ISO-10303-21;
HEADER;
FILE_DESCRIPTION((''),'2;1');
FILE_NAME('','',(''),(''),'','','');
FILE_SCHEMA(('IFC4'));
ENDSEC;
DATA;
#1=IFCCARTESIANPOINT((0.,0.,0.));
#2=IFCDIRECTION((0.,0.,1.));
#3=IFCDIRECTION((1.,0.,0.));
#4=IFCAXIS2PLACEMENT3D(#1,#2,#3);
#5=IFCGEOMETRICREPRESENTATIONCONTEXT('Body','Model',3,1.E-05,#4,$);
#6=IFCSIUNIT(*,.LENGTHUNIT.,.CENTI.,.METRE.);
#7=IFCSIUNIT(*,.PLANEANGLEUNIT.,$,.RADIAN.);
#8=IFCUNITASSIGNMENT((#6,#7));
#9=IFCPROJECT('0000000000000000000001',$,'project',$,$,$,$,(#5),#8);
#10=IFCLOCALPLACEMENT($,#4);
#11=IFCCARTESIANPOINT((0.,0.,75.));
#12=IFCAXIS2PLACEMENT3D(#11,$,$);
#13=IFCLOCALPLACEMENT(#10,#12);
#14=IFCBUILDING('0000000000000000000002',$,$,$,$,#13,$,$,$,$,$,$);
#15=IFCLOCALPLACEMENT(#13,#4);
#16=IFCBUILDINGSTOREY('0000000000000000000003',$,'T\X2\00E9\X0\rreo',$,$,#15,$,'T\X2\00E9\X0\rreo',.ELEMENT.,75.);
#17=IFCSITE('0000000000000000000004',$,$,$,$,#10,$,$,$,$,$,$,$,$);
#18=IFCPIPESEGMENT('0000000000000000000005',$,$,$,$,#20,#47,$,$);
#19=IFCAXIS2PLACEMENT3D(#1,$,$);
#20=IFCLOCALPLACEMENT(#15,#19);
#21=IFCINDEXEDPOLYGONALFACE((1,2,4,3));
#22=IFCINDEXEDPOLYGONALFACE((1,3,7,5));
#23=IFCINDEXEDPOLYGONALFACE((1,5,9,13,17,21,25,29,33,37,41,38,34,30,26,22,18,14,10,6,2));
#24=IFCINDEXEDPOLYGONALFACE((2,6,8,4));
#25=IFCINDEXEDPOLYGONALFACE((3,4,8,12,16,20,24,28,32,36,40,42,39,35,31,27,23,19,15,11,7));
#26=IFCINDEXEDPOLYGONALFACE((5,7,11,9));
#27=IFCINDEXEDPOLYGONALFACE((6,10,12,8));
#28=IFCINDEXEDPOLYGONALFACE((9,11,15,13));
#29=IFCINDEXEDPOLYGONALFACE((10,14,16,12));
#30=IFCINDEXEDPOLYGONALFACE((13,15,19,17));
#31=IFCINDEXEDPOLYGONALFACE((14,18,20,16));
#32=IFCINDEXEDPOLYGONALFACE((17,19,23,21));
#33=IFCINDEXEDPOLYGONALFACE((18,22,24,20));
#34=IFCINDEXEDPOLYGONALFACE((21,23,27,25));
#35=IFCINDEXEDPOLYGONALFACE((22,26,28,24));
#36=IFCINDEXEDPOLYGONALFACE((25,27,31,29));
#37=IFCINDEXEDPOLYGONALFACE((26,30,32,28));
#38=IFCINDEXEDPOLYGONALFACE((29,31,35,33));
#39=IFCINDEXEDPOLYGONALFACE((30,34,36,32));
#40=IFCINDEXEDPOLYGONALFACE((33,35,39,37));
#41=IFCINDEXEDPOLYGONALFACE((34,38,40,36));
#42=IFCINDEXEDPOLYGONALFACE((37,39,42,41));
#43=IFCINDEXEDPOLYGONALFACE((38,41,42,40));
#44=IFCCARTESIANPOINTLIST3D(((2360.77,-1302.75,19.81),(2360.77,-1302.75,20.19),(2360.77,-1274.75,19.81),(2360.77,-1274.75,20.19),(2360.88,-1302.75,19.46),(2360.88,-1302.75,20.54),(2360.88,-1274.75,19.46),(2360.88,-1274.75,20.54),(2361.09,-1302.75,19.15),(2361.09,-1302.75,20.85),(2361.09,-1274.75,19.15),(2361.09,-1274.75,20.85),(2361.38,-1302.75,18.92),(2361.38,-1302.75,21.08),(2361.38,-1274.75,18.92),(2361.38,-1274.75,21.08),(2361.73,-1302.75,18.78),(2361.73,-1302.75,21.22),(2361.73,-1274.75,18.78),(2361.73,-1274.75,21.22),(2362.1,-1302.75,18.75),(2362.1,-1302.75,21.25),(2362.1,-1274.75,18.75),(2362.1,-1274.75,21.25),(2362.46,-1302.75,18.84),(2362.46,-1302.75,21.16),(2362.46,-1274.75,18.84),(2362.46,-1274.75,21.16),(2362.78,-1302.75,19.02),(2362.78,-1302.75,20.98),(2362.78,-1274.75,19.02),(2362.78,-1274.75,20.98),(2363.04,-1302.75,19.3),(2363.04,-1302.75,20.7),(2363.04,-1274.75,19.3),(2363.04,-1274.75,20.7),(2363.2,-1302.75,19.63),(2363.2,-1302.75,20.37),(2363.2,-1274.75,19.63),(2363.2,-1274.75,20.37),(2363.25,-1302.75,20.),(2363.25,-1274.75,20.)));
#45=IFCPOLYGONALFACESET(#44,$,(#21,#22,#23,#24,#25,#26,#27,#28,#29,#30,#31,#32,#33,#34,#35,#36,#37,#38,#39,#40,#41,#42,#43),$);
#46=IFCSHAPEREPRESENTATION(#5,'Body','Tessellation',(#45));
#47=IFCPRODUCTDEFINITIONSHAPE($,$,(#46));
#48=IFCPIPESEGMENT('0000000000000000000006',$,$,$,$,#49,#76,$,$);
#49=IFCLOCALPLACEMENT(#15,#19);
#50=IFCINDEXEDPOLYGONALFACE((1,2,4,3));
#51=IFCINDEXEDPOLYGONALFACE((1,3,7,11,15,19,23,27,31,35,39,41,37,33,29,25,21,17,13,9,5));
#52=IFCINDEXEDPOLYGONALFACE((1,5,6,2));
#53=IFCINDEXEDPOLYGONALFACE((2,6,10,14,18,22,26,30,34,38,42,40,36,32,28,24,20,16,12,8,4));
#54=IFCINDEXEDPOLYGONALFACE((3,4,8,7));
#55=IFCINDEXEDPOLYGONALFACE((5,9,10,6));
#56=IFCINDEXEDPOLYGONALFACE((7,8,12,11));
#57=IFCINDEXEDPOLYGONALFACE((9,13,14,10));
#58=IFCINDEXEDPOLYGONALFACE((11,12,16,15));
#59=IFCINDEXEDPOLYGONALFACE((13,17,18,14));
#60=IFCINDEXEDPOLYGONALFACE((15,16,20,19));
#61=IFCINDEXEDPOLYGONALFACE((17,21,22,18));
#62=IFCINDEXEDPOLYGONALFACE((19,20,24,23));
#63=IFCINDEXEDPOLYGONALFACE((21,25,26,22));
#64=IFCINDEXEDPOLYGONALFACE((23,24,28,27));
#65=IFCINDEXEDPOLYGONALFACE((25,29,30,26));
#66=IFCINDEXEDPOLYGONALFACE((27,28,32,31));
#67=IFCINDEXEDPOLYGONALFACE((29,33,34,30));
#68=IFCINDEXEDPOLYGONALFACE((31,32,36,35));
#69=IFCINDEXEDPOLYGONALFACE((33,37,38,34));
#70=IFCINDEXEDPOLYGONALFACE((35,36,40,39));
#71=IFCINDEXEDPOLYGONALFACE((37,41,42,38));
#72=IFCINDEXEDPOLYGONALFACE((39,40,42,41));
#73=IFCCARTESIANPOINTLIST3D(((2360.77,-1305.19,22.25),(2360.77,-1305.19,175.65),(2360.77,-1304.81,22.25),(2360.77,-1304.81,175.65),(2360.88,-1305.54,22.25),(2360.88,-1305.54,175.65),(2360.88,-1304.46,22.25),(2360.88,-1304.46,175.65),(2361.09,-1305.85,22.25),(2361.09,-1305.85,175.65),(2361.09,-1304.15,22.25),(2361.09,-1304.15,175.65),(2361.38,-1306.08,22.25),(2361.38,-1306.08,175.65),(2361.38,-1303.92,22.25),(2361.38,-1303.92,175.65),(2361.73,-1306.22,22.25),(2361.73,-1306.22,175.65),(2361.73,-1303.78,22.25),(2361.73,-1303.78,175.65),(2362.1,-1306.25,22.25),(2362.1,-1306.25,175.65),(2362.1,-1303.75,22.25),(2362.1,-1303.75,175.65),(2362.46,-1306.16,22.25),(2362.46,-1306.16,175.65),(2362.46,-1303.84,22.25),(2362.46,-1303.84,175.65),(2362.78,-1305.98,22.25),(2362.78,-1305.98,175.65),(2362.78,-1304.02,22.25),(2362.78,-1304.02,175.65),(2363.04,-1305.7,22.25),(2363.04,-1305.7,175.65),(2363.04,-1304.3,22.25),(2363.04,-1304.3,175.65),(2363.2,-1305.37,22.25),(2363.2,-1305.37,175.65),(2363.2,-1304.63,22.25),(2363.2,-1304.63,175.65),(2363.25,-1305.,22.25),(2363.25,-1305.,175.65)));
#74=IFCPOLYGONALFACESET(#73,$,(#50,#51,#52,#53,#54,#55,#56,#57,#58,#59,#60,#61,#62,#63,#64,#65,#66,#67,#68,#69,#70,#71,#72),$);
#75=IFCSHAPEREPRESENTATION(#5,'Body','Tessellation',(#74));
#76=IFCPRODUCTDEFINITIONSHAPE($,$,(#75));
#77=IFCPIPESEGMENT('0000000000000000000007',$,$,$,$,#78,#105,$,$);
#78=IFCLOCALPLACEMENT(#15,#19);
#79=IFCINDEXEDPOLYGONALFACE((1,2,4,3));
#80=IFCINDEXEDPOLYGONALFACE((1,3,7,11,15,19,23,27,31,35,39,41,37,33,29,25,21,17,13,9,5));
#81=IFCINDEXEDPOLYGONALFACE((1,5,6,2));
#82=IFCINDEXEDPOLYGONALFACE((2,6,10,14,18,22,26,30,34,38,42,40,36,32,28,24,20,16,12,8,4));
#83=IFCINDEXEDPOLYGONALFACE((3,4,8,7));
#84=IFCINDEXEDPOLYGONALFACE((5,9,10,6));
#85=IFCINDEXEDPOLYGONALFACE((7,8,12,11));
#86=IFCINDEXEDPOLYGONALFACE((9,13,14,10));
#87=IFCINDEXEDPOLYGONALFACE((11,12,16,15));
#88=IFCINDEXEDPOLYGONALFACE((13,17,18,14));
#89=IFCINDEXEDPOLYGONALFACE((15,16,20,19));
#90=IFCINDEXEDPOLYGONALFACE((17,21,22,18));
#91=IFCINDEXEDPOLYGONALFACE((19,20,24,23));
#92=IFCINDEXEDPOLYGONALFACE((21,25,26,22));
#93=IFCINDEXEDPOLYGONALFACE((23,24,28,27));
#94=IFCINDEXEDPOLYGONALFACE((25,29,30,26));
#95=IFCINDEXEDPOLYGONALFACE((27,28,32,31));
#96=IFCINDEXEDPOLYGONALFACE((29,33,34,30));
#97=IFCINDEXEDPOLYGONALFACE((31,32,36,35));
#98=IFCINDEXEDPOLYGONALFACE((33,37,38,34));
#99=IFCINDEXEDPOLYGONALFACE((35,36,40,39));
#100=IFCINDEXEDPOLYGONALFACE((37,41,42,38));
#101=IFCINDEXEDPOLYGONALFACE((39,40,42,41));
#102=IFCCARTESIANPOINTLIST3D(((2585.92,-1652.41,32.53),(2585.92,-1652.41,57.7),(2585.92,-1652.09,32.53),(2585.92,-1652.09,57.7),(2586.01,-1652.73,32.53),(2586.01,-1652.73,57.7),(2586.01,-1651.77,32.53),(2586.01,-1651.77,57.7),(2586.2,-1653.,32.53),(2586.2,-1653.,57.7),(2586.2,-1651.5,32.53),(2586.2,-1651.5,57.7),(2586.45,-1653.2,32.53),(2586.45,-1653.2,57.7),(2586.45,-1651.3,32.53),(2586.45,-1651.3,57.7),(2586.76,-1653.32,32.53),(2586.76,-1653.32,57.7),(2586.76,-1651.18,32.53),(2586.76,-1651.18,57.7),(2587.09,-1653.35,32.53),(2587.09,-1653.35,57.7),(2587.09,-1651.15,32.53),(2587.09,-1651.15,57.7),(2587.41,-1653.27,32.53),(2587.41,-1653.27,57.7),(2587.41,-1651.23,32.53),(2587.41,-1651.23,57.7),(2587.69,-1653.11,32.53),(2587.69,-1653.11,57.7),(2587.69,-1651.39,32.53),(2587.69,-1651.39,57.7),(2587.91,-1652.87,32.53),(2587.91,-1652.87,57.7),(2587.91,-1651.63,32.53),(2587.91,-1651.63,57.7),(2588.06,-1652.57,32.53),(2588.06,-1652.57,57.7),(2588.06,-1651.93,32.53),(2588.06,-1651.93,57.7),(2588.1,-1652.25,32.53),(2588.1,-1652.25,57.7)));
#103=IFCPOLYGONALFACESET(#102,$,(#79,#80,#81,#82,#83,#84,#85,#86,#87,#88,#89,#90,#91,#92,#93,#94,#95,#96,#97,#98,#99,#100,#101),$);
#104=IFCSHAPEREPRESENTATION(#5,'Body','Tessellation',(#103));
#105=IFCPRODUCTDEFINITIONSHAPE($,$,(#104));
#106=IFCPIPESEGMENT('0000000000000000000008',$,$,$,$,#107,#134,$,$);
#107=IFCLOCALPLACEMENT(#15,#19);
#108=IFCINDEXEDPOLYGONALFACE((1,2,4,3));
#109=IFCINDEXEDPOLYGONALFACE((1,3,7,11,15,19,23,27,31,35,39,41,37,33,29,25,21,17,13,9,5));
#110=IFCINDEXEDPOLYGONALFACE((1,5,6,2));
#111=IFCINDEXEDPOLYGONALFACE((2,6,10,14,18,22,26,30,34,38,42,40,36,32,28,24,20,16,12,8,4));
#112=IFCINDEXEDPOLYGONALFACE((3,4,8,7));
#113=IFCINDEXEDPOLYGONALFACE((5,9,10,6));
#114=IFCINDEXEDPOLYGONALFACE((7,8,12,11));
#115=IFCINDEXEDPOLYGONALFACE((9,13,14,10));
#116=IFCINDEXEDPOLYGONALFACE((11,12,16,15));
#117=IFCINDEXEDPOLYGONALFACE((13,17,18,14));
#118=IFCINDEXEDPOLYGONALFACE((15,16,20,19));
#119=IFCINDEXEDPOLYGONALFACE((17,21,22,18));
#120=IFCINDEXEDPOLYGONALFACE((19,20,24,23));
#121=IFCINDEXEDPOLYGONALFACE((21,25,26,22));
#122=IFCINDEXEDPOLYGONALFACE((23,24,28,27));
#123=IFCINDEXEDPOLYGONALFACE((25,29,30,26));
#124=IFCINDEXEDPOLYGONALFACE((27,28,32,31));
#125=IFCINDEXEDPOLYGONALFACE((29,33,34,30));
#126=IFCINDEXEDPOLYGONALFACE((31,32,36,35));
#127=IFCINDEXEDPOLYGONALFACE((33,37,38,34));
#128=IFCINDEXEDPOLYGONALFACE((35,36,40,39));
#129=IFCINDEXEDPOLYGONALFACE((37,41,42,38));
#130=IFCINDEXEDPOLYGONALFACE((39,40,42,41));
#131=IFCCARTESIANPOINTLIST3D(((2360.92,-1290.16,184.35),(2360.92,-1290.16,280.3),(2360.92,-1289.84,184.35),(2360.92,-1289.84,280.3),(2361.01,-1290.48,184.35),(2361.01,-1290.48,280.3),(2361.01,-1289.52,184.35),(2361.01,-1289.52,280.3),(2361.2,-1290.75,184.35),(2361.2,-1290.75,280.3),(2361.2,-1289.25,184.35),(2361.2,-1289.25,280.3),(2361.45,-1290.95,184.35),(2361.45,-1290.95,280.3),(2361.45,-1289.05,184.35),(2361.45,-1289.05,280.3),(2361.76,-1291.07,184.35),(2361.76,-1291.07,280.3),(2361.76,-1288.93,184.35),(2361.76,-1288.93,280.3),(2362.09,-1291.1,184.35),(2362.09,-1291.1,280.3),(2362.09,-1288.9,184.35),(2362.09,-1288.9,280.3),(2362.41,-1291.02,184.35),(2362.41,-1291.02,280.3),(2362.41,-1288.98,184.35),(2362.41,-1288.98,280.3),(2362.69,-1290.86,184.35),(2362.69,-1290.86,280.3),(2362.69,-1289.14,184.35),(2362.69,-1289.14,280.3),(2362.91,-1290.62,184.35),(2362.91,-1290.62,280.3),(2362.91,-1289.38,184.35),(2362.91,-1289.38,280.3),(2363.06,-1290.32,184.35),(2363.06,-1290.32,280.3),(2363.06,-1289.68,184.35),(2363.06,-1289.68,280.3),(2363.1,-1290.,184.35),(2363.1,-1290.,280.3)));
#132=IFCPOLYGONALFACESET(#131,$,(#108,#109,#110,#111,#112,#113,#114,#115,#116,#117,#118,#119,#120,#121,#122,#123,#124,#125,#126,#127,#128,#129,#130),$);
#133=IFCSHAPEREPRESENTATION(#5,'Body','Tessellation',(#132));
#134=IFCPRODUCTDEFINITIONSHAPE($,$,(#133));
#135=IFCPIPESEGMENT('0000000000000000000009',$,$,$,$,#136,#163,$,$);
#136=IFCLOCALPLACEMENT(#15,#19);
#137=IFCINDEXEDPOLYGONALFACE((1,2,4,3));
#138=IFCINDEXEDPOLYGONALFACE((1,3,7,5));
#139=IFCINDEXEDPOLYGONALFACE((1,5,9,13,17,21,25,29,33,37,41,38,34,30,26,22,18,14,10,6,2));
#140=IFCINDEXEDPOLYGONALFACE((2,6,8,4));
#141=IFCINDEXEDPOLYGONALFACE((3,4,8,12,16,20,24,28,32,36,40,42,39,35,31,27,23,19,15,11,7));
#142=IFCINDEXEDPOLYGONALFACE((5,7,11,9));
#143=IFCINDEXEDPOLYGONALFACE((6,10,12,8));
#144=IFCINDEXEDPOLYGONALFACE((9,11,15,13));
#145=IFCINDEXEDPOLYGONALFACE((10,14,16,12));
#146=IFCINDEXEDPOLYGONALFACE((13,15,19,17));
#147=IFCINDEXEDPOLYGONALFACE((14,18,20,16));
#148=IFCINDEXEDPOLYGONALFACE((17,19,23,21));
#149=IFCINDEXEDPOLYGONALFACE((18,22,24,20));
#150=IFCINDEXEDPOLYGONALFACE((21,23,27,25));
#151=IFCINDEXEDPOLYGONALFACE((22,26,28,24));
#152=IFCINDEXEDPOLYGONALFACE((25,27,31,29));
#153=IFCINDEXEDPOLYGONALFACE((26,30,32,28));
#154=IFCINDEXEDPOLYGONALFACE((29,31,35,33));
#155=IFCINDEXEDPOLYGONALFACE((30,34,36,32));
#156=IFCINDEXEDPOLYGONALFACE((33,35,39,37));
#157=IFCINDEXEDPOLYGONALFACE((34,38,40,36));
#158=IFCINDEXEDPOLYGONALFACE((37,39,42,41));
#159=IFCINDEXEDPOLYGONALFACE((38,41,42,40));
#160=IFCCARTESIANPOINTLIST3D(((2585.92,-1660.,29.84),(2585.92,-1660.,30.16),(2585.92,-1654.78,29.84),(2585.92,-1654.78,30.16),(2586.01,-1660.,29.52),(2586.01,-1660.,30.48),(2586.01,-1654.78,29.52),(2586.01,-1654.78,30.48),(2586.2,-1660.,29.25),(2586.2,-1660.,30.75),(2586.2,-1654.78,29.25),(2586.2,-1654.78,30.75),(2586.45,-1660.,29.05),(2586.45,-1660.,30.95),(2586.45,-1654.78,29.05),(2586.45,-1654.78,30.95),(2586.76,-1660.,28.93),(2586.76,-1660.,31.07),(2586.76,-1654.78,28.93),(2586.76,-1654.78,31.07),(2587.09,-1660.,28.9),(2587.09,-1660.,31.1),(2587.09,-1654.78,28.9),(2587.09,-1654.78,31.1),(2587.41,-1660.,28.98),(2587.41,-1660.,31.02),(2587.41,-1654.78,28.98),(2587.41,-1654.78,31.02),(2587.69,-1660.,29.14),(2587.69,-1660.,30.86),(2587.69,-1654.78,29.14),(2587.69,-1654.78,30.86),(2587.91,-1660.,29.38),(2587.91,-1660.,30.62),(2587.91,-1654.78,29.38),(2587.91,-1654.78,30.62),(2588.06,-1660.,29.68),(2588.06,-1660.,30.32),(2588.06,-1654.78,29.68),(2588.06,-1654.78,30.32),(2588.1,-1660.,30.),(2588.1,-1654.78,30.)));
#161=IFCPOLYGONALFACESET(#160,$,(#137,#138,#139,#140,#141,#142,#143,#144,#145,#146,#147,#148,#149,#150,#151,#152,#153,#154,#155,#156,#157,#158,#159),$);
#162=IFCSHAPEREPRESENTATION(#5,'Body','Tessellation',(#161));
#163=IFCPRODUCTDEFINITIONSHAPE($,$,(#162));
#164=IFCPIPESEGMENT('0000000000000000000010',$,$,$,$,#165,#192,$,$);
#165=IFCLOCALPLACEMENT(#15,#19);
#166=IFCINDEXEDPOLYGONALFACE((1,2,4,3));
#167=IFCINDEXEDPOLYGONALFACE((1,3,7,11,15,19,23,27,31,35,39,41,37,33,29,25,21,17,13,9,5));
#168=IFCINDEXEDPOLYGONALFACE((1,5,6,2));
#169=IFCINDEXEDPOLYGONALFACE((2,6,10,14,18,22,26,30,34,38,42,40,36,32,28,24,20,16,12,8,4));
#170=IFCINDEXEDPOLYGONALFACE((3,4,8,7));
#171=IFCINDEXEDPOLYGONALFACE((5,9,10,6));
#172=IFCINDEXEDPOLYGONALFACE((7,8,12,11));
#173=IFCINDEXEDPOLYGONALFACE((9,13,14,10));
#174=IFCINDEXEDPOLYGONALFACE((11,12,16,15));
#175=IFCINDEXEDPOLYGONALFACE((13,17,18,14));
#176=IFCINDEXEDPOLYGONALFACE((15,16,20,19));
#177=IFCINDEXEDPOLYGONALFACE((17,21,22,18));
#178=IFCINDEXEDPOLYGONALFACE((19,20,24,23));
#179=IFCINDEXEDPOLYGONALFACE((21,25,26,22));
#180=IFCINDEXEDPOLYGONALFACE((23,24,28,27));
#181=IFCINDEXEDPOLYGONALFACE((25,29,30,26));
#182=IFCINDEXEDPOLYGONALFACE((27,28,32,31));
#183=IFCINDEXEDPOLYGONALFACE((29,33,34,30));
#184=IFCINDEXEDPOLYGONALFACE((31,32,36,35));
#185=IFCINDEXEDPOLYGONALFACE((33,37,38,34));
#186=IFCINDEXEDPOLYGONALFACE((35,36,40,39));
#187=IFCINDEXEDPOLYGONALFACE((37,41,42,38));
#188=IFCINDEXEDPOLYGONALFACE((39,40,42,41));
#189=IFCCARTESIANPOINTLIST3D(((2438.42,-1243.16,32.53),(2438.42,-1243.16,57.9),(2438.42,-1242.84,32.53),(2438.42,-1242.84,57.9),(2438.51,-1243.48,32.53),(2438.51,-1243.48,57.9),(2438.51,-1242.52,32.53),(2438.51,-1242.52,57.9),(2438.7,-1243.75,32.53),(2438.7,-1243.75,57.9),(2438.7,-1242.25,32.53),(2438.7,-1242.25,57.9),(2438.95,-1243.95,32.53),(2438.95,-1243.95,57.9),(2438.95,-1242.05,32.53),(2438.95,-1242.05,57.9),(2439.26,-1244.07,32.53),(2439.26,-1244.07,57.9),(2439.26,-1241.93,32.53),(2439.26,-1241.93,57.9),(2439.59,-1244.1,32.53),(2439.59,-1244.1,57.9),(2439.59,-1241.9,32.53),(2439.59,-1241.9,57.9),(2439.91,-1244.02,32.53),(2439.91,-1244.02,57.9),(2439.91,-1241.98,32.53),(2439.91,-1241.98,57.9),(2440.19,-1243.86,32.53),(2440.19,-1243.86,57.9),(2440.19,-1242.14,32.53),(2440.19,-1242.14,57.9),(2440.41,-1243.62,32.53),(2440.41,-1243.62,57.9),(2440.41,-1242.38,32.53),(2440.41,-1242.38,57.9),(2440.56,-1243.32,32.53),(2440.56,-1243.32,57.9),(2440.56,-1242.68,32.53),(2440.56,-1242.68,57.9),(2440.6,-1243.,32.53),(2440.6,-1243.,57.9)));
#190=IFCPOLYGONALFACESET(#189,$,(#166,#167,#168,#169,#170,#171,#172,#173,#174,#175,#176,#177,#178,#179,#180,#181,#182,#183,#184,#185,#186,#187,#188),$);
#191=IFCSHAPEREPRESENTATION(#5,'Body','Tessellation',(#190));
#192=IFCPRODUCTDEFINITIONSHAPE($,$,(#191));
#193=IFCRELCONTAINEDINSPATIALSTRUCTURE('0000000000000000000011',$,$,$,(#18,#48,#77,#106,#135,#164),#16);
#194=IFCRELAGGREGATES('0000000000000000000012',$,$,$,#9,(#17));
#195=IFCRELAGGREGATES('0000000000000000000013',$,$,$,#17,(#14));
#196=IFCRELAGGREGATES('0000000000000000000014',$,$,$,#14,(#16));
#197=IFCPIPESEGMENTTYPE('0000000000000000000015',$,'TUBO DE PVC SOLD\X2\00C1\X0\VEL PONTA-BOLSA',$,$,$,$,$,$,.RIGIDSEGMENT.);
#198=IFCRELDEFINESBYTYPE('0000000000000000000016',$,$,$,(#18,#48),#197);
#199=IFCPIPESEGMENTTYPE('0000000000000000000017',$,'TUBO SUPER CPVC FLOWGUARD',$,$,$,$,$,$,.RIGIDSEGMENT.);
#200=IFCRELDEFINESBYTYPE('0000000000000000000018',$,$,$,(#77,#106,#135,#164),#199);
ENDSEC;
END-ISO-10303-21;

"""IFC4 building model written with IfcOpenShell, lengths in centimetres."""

from ifc_helpers import new_model, si_unit, frame, origin_with_axes, origin_2d_with_axis, place, context, project, spatial, circle, extrude, type_object, element, save


model = new_model("IFC4")

# Units and contexts
model_context = context("Model", 3, precision=1e-05, world=origin_with_axes(), identifier="Body")
ifc_project = project(units=[si_unit("LENGTHUNIT", "METRE", prefix="CENTI"), si_unit("PLANEANGLEUNIT", "RADIAN")], contexts=[model_context])

# Site, building, storey
site_placement = place(None, origin_with_axes())
site = spatial("IfcSite", under=ifc_project, at=site_placement)
building_placement = place(site_placement, frame((0.0, 0.0, 75.0)))
building = spatial("IfcBuilding", under=site, at=building_placement)
storey_placement = place(building_placement, origin_with_axes())
storey = spatial("IfcBuildingStorey", under=building, at=storey_placement, Name="Térreo", LongName="Térreo", CompositionType="ELEMENT", Elevation=75.0)

# Pipe segments
pipe_segment_type_1 = type_object("IfcPipeSegmentType", Name="TUBO DE PVC SOLDÁVEL PONTA-BOLSA", PredefinedType="RIGIDSEGMENT")
pipe_segment_1_placement = place(storey_placement, frame((2362.0, -1288.75, 21.25), z_axis=(0.0, 0.0, 1.0), x_axis=(1.0, 0.0, 0.0)))
element("IfcPipeSegment", 1, at=pipe_segment_1_placement, inside=storey, type_object=pipe_segment_type_1, context=model_context, shape_type="SolidModel", body=[
    extrude(circle(Radius=1.25, at=origin_2d_with_axis()), frame((0.0, -14.0, -1.25), z_axis=(0.0, 1.0, 0.0), x_axis=(1.0, 0.0, 0.0)), (0.0, 0.0, 1.0), 28.0),
])
pipe_segment_2_placement = place(storey_placement, frame((2362.0, -1305.0, 175.65), z_axis=(0.0, 0.0, 1.0), x_axis=(1.0, 0.0, 0.0)))
element("IfcPipeSegment", 2, at=pipe_segment_2_placement, inside=storey, type_object=pipe_segment_type_1, context=model_context, shape_type="SolidModel", body=[
    extrude(circle(Radius=1.25, at=origin_2d_with_axis()), frame((0.0, 0.0, 0.0), z_axis=(0.0, 0.0, -1.0), x_axis=(1.0, 0.0, 0.0)), (0.0, 0.0, 1.0), 153.4),
])
pipe_segment_type_2 = type_object("IfcPipeSegmentType", Name="TUBO SUPER CPVC FLOWGUARD", PredefinedType="RIGIDSEGMENT")
pipe_segment_3_placement = place(storey_placement, frame((2587.0, -1652.25, 57.7), z_axis=(0.0, 0.0, 1.0), x_axis=(1.0, 0.0, 0.0)))
element("IfcPipeSegment", 3, at=pipe_segment_3_placement, inside=storey, type_object=pipe_segment_type_2, context=model_context, shape_type="SolidModel", body=[
    extrude(circle(Radius=1.1, at=origin_2d_with_axis()), frame((0.0, 0.0, -25.17), z_axis=(0.0, 0.0, 1.0), x_axis=(1.0, 0.0, 0.0)), (0.0, 0.0, 1.0), 25.17),
])
pipe_segment_4_placement = place(storey_placement, frame((2362.0, -1290.0, 280.3), z_axis=(0.0, 0.0, 1.0), x_axis=(1.0, 0.0, 0.0)))
element("IfcPipeSegment", 4, at=pipe_segment_4_placement, inside=storey, type_object=pipe_segment_type_2, context=model_context, shape_type="SolidModel", body=[
    extrude(circle(Radius=1.1, at=origin_2d_with_axis()), frame((0.0, 0.0, 0.0), z_axis=(0.0, 0.0, -1.0), x_axis=(1.0, 0.0, 0.0)), (0.0, 0.0, 1.0), 95.95),
])
pipe_segment_5_placement = place(storey_placement, frame((2587.0, -1657.39, 31.1), z_axis=(0.0, 0.0, 1.0), x_axis=(1.0, 0.0, 0.0)))
element("IfcPipeSegment", 5, at=pipe_segment_5_placement, inside=storey, type_object=pipe_segment_type_2, context=model_context, shape_type="SolidModel", body=[
    extrude(circle(Radius=1.1, at=origin_2d_with_axis()), frame((0.0, -2.61, -1.1), z_axis=(0.0, 1.0, 0.0), x_axis=(1.0, 0.0, 0.0)), (0.0, 0.0, 1.0), 5.22),
])
pipe_segment_6_placement = place(storey_placement, frame((2439.5, -1243.0, 57.9), z_axis=(0.0, 0.0, 1.0), x_axis=(1.0, 0.0, 0.0)))
element("IfcPipeSegment", 6, at=pipe_segment_6_placement, inside=storey, type_object=pipe_segment_type_2, context=model_context, shape_type="SolidModel", body=[
    extrude(circle(Radius=1.1, at=origin_2d_with_axis()), frame((0.0, 0.0, -25.37), z_axis=(0.0, 0.0, 1.0), x_axis=(1.0, 0.0, 0.0)), (0.0, 0.0, 1.0), 25.37),
])

save(model, "model.ifc")
